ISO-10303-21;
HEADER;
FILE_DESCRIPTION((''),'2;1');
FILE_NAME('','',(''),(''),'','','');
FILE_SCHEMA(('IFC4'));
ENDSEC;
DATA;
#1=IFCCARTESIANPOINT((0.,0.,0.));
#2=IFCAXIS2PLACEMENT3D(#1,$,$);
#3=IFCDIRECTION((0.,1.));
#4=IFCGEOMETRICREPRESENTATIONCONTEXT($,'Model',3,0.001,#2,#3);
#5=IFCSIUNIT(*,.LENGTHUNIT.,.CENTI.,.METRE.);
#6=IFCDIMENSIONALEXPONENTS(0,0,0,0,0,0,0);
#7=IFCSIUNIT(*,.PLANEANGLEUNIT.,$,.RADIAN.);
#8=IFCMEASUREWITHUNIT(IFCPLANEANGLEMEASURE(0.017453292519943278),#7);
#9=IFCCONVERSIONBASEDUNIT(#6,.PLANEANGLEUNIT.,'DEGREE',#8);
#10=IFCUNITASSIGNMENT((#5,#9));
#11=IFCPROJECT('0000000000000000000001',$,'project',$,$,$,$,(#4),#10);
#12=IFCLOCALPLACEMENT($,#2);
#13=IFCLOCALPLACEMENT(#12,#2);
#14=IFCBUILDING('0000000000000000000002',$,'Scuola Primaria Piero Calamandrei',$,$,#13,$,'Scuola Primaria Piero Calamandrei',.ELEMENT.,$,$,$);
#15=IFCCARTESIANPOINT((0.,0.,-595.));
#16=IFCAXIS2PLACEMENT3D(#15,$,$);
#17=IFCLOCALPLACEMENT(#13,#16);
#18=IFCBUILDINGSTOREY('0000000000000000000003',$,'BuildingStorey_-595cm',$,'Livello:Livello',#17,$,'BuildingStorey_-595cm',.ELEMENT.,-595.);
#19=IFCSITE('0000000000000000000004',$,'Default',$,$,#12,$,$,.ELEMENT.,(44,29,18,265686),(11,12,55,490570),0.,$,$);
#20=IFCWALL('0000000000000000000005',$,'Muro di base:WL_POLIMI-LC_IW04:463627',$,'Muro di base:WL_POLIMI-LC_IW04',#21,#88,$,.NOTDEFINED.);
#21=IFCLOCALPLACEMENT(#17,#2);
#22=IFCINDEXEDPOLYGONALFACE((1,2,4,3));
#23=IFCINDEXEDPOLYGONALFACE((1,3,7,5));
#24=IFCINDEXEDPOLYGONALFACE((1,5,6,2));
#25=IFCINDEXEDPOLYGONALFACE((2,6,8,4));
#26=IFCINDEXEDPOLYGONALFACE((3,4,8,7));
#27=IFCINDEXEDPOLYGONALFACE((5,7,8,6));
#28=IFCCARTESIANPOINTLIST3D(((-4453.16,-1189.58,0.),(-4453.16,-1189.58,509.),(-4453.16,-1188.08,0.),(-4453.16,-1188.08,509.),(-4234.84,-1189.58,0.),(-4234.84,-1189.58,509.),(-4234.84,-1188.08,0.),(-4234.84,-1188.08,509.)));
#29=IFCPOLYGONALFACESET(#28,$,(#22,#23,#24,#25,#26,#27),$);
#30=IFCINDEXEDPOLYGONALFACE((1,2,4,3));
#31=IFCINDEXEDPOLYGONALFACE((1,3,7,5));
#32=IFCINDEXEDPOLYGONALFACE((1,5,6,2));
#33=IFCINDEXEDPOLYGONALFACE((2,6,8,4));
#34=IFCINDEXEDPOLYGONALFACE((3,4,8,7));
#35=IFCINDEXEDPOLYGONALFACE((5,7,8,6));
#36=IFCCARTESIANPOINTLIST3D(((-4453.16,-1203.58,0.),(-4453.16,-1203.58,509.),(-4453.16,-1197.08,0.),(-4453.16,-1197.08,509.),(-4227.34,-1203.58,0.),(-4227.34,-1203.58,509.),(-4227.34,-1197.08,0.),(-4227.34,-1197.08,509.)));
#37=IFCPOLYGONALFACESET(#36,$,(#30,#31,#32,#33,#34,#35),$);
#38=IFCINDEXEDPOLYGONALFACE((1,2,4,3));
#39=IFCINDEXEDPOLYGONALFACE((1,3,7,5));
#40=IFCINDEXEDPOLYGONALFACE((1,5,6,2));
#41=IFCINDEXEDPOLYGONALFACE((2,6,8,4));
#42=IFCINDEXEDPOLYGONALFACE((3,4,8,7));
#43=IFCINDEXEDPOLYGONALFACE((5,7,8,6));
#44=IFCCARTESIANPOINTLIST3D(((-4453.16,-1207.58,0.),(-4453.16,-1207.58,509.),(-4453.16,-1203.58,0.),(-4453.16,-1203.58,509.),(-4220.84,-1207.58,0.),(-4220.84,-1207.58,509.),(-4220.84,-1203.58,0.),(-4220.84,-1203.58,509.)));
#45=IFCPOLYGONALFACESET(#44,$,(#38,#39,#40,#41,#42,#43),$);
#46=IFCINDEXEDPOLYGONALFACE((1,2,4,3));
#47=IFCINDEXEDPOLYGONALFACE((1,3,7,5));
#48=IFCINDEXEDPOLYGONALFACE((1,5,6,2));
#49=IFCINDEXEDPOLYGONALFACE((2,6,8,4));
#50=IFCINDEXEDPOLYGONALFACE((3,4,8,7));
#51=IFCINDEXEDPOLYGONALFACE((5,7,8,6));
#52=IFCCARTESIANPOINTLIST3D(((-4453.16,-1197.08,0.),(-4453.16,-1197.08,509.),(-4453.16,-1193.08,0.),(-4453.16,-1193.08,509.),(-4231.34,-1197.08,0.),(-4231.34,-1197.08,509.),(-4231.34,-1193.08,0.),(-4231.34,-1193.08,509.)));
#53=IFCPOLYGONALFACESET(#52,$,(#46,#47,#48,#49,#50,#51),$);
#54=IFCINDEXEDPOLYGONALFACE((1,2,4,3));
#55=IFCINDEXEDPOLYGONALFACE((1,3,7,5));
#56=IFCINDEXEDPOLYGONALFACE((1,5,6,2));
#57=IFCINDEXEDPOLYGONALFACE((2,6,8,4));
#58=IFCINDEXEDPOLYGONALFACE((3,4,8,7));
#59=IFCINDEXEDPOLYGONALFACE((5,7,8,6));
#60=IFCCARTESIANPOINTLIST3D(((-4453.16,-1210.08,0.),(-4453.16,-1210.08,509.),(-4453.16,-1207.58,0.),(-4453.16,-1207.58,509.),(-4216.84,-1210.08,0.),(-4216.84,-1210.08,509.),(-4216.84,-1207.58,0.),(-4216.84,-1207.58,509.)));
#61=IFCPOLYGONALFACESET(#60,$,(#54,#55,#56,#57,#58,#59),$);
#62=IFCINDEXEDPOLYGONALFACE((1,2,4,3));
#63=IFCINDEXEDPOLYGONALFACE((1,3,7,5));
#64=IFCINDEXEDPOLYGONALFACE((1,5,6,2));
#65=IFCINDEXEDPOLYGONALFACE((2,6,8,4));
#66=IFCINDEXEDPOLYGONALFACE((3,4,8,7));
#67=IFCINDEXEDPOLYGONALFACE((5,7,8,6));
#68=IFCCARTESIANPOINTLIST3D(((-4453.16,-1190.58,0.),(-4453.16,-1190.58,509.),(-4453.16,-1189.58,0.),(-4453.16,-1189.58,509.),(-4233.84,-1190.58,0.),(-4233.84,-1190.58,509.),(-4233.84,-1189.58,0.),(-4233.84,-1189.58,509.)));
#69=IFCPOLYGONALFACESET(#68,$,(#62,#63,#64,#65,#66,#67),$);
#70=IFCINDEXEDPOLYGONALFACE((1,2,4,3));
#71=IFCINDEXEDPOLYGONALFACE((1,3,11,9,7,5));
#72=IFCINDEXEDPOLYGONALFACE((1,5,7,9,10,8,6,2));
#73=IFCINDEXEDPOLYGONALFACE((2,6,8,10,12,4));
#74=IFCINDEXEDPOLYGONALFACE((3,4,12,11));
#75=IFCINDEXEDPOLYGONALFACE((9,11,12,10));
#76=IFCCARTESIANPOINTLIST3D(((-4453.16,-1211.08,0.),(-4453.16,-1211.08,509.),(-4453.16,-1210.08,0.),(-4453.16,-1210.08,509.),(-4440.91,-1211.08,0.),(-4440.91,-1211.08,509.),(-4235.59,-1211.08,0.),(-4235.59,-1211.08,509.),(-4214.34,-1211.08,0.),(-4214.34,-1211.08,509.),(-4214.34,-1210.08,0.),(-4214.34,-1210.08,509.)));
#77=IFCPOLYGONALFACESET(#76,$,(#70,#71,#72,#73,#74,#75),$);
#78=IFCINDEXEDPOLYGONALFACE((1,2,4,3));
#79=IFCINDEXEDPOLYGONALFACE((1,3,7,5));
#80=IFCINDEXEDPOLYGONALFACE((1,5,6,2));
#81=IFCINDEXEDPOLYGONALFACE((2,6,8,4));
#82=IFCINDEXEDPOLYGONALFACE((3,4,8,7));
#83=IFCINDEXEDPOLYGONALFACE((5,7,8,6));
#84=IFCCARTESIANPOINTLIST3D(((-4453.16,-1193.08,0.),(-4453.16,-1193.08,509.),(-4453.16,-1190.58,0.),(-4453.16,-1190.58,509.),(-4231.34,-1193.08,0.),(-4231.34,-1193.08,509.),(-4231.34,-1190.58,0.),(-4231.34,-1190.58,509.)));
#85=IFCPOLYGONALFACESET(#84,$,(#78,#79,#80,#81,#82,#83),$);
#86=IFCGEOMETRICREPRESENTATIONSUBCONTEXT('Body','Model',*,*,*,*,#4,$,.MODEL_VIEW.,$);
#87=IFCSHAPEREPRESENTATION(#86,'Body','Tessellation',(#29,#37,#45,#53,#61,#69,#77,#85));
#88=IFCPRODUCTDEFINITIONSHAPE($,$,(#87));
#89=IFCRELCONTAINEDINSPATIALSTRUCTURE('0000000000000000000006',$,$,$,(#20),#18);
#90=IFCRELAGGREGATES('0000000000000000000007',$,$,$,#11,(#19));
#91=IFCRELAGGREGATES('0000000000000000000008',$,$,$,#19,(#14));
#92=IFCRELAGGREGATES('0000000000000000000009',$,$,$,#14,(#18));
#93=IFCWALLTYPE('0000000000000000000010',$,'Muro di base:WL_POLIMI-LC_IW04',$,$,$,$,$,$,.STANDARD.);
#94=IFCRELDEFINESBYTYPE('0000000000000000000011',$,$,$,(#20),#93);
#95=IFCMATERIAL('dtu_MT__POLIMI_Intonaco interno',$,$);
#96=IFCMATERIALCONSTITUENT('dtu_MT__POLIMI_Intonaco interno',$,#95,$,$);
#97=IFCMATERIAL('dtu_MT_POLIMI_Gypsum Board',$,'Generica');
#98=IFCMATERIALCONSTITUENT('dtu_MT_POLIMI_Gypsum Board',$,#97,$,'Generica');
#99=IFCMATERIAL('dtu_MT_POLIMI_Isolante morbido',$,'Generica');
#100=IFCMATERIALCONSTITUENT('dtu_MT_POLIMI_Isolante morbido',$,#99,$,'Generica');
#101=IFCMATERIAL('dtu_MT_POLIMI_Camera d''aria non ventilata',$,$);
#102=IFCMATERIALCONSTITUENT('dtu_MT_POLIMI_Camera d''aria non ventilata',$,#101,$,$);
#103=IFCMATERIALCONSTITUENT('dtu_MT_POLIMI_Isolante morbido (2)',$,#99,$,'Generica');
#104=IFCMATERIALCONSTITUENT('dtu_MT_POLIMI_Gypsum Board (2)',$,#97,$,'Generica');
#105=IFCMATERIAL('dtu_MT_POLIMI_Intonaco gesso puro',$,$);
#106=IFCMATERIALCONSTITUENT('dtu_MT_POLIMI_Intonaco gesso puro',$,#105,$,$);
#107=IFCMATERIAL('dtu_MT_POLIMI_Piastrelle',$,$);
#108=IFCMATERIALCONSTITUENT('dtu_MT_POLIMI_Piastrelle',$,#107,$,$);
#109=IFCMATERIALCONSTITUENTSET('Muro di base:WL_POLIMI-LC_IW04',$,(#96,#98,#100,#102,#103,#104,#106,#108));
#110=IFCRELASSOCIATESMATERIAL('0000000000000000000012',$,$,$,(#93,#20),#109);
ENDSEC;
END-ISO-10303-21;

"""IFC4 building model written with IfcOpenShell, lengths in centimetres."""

from ifc_helpers import new_model, entity, si_unit, converted_unit, direction, frame, origin, place, context, subcontext, project, spatial, indexed_curve, outline, extrude, material, constituent, constituent_set, type_object, element, save


model = new_model("IFC4")

# Units and contexts
model_context = context("Model", 3, precision=0.001, world=origin(), true_north=direction((0.0, 1.0)))
body_context = subcontext(model_context, "Body", "Model", "MODEL_VIEW")
ifc_project = project(units=[si_unit("LENGTHUNIT", "METRE", prefix="CENTI"), converted_unit("PLANEANGLEUNIT", "DEGREE", entity("IfcPlaneAngleMeasure", 0.017453292519943278), si_unit("PLANEANGLEUNIT", "RADIAN"), dimensions=[0, 0, 0, 0, 0, 0, 0])], contexts=[model_context])

# Site, building, storey
site_placement = place(None, origin())
site = spatial("IfcSite", under=ifc_project, at=site_placement, Name="Default", CompositionType="ELEMENT", RefLatitude=(44, 29, 18, 265686), RefLongitude=(11, 12, 55, 490570), RefElevation=0.0)
building_placement = place(site_placement, origin())
building = spatial("IfcBuilding", under=site, at=building_placement, Name="Scuola Primaria Piero Calamandrei", LongName="Scuola Primaria Piero Calamandrei", CompositionType="ELEMENT")
storey_placement = place(building_placement, frame((0.0, 0.0, -595.0)))
storey = spatial("IfcBuildingStorey", under=building, at=storey_placement, Name="BuildingStorey_-595cm", ObjectType="Livello:Livello", LongName="BuildingStorey_-595cm", CompositionType="ELEMENT", Elevation=-595.0)

# Shared definitions
ifc_material_1 = material(Name="dtu_MT__POLIMI_Intonaco interno")

# Shared definitions
ifc_material_2 = material(Name="dtu_MT_POLIMI_Gypsum Board", Category="Generica")
ifc_material_3 = material(Name="dtu_MT_POLIMI_Isolante morbido", Category="Generica")
ifc_material_4 = material(Name="dtu_MT_POLIMI_Camera d'aria non ventilata")
ifc_material_5 = material(Name="dtu_MT_POLIMI_Intonaco gesso puro")

# Wall
ifc_constituent_1 = constituent(ifc_material_1, Name="dtu_MT__POLIMI_Intonaco interno")
ifc_constituent_2 = constituent(ifc_material_2, Name="dtu_MT_POLIMI_Gypsum Board", Category="Generica")
ifc_constituent_3 = constituent(ifc_material_3, Name="dtu_MT_POLIMI_Isolante morbido", Category="Generica")
ifc_constituent_4 = constituent(ifc_material_4, Name="dtu_MT_POLIMI_Camera d'aria non ventilata")
ifc_constituent_5 = constituent(ifc_material_3, Name="dtu_MT_POLIMI_Isolante morbido (2)", Category="Generica")
ifc_constituent_6 = constituent(ifc_material_2, Name="dtu_MT_POLIMI_Gypsum Board (2)", Category="Generica")
ifc_constituent_7 = constituent(ifc_material_5, Name="dtu_MT_POLIMI_Intonaco gesso puro")
ifc_material_6 = material(Name="dtu_MT_POLIMI_Piastrelle")
ifc_constituent_8 = constituent(ifc_material_6, Name="dtu_MT_POLIMI_Piastrelle")
ifc_constituent_set_1 = constituent_set(constituents=[ifc_constituent_1, ifc_constituent_2, ifc_constituent_3, ifc_constituent_4, ifc_constituent_5, ifc_constituent_6, ifc_constituent_7, ifc_constituent_8], Name="Muro di base:WL_POLIMI-LC_IW04")
wall_type_1 = type_object("IfcWallType", Name="Muro di base:WL_POLIMI-LC_IW04", PredefinedType="STANDARD", material=ifc_constituent_set_1)
wall_1_placement = place(storey_placement, frame((-4234.84, -1199.58, 0.0), z_axis=(0.0, 0.0, 1.0), x_axis=(-1.0, 0.0, 0.0)))
element("IfcWall", 1, at=wall_1_placement, inside=storey, type_object=wall_type_1, material=ifc_constituent_set_1, Name="Muro di base:WL_POLIMI-LC_IW04:463627", ObjectType="Muro di base:WL_POLIMI-LC_IW04", PredefinedType="NOTDEFINED", context=body_context, shape_type="SweptSolid", body=[
    extrude(outline(indexed_curve([(-0.75, -109.16), (0.75, -109.16), (0.75, 109.16), (-0.75, 109.16), (-0.75, -109.16)], self_intersect=False)), frame((109.16, -10.75, 0.0), z_axis=(0.0, 0.0, 1.0), x_axis=(0.0, 1.0, 0.0)), (0.0, 0.0, 1.0), 509.0),
    extrude(outline(indexed_curve([(-112.91, -3.25), (112.91, -3.25), (112.91, 3.25), (-112.91, 3.25), (-112.91, -3.25)], self_intersect=False)), frame((105.41, 0.75, 0.0)), (0.0, 0.0, 1.0), 509.0),
    extrude(outline(indexed_curve([(-116.16, -2.0), (116.16, -2.0), (116.16, 2.0), (-116.16, 2.0), (-116.16, -2.0)], self_intersect=False)), frame((102.16, 6.0, 0.0)), (0.0, 0.0, 1.0), 509.0),
    extrude(outline(indexed_curve([(-110.91, -2.0), (110.91, -2.0), (110.91, 2.0), (-110.91, 2.0), (-110.91, -2.0)], self_intersect=False)), frame((107.41, -4.5, 0.0)), (0.0, 0.0, 1.0), 509.0),
    extrude(outline(indexed_curve([(-118.16, -1.25), (118.16, -1.25), (118.16, 1.25), (-118.16, 1.25), (-118.16, -1.25)], self_intersect=False)), frame((100.16, 9.25, 0.0)), (0.0, 0.0, 1.0), 509.0),
    extrude(outline(indexed_curve([(-109.66, -0.5), (109.66, -0.5), (109.66, 0.5), (-109.66, 0.5), (-109.66, -0.5)], self_intersect=False)), frame((108.66, -9.5, 0.0)), (0.0, 0.0, 1.0), 509.0),
    extrude(outline(indexed_curve([(-105.66, -0.33), (99.66, -0.33), (120.91, -0.33), (120.91, 0.67), (-117.91, 0.67), (-117.91, -0.33), (-105.66, -0.33)], self_intersect=False)), frame((100.41, 11.17, 0.0), z_axis=(0.0, 0.0, 1.0), x_axis=(-1.0, 0.0, 0.0)), (0.0, 0.0, 1.0), 509.0),
    extrude(outline(indexed_curve([(-110.91, -1.25), (110.91, -1.25), (110.91, 1.25), (-110.91, 1.25), (-110.91, -1.25)], self_intersect=False)), frame((107.41, -7.75, 0.0)), (0.0, 0.0, 1.0), 509.0),
])

save(model, "model.ifc")
